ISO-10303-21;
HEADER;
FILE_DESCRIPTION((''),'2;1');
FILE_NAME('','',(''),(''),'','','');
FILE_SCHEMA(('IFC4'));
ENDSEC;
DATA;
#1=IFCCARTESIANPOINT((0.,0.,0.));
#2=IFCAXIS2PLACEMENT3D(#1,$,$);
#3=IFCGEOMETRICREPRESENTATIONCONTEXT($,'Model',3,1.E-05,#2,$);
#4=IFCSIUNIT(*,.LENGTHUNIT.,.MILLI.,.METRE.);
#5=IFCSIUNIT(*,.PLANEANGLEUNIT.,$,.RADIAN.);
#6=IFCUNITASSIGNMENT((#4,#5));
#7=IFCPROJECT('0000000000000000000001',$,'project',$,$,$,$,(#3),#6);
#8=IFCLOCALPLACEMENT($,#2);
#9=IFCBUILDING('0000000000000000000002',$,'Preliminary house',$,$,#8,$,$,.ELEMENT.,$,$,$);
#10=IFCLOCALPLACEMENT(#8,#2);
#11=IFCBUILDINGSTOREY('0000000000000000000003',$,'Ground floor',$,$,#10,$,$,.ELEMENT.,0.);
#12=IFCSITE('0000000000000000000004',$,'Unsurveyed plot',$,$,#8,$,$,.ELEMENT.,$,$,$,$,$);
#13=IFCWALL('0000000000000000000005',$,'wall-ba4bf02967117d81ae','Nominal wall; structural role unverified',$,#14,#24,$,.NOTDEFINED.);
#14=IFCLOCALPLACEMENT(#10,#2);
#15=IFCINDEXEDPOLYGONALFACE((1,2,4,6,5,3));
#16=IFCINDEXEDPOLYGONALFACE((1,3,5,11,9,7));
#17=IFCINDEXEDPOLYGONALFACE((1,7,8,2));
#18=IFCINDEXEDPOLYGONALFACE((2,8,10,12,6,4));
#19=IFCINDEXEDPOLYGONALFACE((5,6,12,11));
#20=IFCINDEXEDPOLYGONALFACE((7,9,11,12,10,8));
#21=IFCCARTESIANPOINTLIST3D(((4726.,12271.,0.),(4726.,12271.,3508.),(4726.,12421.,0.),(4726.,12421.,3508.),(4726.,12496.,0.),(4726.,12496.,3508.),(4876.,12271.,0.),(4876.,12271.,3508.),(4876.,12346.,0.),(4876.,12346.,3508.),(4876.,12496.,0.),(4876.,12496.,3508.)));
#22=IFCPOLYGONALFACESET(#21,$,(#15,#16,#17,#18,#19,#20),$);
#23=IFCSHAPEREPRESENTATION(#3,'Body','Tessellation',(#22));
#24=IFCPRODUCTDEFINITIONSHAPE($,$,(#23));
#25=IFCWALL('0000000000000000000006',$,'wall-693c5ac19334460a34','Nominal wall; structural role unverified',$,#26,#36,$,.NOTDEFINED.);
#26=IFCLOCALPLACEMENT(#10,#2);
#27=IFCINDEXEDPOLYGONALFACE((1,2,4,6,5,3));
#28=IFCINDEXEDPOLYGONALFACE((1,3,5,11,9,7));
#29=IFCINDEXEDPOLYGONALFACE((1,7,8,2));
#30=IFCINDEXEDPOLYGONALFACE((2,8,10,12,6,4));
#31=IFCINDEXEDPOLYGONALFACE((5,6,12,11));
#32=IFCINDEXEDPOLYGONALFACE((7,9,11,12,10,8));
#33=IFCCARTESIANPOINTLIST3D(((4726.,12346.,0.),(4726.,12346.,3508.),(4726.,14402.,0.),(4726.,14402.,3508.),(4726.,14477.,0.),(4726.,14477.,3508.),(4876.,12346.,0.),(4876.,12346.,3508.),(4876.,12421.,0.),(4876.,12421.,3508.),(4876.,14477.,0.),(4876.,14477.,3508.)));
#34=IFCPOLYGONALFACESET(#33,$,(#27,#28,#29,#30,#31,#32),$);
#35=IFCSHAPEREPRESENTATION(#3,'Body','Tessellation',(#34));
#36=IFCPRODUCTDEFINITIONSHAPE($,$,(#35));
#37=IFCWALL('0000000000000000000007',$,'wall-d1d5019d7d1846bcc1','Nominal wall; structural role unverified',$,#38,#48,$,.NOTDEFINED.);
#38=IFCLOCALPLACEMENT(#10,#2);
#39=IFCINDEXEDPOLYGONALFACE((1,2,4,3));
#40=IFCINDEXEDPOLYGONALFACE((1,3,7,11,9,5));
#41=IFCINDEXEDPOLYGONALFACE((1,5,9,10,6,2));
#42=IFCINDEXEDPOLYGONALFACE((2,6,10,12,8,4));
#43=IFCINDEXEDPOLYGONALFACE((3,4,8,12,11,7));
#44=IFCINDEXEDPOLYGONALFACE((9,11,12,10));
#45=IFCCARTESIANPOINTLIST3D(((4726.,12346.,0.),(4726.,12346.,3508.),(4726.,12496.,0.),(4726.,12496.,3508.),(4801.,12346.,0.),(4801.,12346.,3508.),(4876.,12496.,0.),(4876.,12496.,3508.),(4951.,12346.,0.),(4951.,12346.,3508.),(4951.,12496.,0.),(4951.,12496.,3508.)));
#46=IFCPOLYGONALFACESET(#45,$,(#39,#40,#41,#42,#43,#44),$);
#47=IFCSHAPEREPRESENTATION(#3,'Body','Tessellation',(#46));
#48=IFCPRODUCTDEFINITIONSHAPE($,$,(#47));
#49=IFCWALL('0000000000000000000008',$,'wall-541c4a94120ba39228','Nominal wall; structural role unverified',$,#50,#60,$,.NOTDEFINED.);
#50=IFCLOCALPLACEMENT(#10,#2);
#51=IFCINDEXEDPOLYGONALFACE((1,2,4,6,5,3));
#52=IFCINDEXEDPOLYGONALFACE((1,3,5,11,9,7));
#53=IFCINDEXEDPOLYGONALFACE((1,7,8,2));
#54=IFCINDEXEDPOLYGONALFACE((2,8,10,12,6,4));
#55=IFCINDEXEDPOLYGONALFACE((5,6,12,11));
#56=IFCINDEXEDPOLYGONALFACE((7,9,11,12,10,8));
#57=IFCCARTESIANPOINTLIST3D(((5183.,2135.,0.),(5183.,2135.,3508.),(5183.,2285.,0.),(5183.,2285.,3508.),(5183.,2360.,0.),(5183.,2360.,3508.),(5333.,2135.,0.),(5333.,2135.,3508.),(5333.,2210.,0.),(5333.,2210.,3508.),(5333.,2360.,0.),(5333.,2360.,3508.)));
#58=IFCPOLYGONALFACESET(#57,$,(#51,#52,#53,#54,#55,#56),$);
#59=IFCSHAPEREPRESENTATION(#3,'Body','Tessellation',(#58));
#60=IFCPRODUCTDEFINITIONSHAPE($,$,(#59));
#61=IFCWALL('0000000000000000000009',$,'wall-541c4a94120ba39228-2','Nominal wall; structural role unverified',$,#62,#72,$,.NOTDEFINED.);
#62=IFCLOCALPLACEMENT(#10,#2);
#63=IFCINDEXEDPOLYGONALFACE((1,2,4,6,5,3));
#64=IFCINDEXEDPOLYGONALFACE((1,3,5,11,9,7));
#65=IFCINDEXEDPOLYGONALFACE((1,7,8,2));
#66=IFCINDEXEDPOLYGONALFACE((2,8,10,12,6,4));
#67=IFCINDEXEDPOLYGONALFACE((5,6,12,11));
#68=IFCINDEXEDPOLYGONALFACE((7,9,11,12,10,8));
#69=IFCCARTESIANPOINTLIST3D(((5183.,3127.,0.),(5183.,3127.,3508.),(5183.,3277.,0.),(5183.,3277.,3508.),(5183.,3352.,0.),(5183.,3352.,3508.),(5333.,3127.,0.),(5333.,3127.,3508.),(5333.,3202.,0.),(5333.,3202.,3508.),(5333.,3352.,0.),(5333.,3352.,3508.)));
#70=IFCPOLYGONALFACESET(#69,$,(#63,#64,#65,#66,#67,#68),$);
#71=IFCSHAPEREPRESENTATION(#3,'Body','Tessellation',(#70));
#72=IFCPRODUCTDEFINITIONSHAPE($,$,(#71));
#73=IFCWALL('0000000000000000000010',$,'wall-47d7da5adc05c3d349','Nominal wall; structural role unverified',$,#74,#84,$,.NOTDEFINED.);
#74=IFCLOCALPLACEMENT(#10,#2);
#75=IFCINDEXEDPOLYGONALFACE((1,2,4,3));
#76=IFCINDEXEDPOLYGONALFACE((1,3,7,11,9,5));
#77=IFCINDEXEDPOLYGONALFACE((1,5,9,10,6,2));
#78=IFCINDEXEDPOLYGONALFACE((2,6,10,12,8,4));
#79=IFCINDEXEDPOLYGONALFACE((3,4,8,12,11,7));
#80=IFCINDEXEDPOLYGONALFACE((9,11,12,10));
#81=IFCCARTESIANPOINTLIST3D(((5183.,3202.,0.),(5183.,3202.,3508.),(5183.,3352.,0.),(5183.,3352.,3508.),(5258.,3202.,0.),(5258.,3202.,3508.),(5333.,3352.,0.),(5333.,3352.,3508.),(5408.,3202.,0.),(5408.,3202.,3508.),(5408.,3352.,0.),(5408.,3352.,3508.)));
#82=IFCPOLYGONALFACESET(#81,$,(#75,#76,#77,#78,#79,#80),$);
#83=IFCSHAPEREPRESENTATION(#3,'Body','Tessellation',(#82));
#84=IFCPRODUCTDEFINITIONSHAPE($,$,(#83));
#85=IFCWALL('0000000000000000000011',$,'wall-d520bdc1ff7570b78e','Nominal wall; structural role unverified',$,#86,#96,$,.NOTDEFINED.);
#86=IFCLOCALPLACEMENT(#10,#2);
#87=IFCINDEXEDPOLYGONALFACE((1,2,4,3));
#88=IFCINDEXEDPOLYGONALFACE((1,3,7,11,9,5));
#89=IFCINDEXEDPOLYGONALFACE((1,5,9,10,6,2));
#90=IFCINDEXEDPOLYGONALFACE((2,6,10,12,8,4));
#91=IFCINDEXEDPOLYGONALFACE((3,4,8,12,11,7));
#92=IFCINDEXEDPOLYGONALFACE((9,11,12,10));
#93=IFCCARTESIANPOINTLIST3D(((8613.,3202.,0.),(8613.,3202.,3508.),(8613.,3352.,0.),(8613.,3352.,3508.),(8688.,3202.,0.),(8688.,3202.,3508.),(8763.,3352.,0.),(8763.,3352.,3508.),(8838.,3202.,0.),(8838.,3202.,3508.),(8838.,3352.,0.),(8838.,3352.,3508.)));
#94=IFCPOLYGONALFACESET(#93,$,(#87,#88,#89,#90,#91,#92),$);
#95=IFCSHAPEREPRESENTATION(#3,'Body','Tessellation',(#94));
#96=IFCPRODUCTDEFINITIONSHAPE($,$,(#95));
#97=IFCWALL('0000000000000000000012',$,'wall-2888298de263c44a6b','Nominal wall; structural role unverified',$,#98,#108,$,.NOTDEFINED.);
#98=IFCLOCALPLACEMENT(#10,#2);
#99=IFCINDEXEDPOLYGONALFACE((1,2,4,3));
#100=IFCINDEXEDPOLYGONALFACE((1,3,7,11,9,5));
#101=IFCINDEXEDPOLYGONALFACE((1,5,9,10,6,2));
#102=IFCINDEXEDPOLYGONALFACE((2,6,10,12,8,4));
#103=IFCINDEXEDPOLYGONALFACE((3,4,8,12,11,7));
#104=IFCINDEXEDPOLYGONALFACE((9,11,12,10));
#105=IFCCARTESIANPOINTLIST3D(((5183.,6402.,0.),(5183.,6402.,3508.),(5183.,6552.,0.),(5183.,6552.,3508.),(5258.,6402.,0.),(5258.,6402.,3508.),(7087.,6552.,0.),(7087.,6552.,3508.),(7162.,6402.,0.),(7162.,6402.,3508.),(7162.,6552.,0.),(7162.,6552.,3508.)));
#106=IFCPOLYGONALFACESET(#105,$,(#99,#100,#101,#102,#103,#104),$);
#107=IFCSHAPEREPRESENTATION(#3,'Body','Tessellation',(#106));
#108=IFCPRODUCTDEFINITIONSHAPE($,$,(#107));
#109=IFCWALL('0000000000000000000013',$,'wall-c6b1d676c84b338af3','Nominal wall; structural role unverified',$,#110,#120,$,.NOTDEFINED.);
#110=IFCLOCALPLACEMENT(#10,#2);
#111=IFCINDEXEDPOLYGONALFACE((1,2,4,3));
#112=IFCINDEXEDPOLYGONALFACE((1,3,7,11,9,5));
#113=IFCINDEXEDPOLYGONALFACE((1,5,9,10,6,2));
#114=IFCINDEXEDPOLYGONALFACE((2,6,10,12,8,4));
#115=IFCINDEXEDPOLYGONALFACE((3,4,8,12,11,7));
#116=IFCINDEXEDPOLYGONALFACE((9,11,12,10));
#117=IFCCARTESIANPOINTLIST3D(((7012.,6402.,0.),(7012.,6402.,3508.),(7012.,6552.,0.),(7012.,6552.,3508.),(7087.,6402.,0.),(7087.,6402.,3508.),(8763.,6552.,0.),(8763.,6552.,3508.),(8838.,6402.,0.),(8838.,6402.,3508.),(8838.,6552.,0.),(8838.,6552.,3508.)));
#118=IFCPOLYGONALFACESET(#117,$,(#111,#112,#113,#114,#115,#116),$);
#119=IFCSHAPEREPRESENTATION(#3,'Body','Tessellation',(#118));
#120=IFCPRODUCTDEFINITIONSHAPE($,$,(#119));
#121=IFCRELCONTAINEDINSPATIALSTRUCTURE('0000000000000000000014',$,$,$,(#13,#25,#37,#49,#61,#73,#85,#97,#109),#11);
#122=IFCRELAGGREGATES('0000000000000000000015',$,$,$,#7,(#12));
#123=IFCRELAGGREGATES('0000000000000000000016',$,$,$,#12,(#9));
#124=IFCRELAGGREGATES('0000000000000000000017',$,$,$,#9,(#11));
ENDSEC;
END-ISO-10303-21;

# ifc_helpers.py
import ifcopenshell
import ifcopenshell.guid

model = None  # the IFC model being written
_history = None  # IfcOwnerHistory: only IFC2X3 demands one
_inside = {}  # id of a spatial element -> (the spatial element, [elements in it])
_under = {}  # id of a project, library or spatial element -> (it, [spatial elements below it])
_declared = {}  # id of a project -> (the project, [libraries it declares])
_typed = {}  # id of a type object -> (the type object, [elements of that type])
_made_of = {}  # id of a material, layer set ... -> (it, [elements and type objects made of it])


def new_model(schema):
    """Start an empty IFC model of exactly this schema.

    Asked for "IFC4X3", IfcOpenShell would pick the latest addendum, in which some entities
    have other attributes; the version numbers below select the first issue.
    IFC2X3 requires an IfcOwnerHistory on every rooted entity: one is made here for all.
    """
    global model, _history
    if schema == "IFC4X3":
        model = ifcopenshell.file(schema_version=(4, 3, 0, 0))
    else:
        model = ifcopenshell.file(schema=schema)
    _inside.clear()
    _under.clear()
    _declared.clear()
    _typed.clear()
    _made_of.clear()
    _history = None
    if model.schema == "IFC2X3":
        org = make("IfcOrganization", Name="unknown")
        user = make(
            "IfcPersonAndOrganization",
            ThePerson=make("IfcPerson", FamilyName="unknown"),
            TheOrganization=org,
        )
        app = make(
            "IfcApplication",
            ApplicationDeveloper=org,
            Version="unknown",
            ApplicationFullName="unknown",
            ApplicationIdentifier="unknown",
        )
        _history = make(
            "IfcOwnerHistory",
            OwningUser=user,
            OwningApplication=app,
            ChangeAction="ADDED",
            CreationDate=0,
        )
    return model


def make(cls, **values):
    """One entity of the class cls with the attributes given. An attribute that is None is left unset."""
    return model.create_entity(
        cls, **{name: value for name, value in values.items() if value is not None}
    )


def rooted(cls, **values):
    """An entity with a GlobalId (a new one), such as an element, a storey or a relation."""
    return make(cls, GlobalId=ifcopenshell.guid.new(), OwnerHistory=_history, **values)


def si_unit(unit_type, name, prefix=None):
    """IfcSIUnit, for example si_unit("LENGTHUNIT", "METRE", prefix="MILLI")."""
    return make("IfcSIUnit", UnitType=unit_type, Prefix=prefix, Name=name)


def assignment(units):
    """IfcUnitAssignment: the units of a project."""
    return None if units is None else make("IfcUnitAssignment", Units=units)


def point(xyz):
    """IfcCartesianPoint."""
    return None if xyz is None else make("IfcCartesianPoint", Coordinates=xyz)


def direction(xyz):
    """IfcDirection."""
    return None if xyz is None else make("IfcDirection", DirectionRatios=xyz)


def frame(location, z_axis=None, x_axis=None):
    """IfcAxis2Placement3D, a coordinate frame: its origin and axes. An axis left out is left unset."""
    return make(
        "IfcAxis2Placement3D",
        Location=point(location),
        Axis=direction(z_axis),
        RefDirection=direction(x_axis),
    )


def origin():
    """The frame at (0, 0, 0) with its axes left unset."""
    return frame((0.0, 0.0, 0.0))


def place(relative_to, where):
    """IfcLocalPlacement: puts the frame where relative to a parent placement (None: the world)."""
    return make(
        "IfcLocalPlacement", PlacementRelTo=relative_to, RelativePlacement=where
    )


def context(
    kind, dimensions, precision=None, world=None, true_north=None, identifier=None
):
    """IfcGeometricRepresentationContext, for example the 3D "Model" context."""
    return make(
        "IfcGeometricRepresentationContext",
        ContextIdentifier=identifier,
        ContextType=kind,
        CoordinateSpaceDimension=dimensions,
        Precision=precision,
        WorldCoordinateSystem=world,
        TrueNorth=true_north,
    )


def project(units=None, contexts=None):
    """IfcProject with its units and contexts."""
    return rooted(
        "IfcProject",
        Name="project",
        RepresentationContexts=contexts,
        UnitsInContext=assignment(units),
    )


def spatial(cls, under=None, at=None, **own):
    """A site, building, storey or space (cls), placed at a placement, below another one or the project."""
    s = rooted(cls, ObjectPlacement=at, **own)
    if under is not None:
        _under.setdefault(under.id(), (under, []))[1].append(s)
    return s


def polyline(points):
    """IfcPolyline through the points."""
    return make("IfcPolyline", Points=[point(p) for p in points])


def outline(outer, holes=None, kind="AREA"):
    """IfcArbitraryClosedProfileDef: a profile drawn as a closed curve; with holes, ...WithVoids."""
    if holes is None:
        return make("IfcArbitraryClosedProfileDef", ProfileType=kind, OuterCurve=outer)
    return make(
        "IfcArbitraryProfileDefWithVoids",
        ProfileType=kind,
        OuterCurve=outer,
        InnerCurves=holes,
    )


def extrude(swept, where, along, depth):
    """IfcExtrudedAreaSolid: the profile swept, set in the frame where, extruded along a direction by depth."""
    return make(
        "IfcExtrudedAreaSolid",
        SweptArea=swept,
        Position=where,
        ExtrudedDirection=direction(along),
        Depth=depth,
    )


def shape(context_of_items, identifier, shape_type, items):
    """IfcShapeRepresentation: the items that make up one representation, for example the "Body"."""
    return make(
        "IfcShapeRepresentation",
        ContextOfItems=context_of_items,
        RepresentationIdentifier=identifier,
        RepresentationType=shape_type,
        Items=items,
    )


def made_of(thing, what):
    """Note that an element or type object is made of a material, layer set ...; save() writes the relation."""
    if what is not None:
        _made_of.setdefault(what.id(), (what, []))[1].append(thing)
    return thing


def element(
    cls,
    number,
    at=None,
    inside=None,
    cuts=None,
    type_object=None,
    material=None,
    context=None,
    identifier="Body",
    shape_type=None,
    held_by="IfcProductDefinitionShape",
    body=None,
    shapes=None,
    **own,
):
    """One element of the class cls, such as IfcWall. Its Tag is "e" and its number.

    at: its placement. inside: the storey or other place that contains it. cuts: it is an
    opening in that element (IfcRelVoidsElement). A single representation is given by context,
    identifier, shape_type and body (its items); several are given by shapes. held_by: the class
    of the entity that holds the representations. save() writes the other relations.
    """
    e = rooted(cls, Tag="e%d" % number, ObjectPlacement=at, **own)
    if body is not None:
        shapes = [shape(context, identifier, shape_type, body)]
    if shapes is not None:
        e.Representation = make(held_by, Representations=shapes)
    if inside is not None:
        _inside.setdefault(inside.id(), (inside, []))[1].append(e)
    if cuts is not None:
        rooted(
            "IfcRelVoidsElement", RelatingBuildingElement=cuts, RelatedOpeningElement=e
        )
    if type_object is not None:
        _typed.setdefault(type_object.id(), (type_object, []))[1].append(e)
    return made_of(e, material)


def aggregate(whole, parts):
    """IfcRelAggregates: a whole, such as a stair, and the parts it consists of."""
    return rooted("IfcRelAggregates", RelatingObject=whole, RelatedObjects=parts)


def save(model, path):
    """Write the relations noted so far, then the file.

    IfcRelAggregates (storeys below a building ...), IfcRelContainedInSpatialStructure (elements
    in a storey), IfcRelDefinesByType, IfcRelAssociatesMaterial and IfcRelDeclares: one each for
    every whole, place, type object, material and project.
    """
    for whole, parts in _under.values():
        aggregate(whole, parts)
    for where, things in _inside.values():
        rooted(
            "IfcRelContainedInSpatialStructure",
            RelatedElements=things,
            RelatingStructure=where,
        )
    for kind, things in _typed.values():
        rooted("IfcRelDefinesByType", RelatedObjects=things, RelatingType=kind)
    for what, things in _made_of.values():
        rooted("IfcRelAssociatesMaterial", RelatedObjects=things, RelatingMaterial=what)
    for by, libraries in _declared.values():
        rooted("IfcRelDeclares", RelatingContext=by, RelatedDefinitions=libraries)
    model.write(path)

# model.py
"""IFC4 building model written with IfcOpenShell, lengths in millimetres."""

from ifc_helpers import new_model, si_unit, origin, place, context, project, spatial, polyline, outline, extrude, element, save


model = new_model("IFC4")

# Units and contexts
model_context = context("Model", 3, precision=1e-05, world=origin())
ifc_project = project(units=[si_unit("LENGTHUNIT", "METRE", prefix="MILLI"), si_unit("PLANEANGLEUNIT", "RADIAN")], contexts=[model_context])

# Site, building, storey
placement_1 = place(None, origin())
site = spatial("IfcSite", under=ifc_project, at=placement_1, Name="Unsurveyed plot", CompositionType="ELEMENT")
building = spatial("IfcBuilding", under=site, at=placement_1, Name="Preliminary house", CompositionType="ELEMENT")
placement_2 = place(placement_1, origin())
storey = spatial("IfcBuildingStorey", under=building, at=placement_2, Name="Ground floor", CompositionType="ELEMENT", Elevation=0.0)

# Walls
element("IfcWall", 1, at=placement_2, inside=storey, Name="wall-ba4bf02967117d81ae", Description="Nominal wall; structural role unverified", PredefinedType="NOTDEFINED", context=model_context, shape_type="SweptSolid", body=[
    extrude(outline(polyline([(4726.0, 12421.0), (4726.0, 12496.0), (4876.0, 12496.0), (4876.0, 12346.0), (4876.0, 12271.0), (4726.0, 12271.0), (4726.0, 12421.0)])), origin(), (0.0, 0.0, 1.0), 3508.0),
])
element("IfcWall", 2, at=placement_2, inside=storey, Name="wall-693c5ac19334460a34", Description="Nominal wall; structural role unverified", PredefinedType="NOTDEFINED", context=model_context, shape_type="SweptSolid", body=[
    extrude(outline(polyline([(4726.0, 14402.0), (4726.0, 14477.0), (4876.0, 14477.0), (4876.0, 12421.0), (4876.0, 12346.0), (4726.0, 12346.0), (4726.0, 14402.0)])), origin(), (0.0, 0.0, 1.0), 3508.0),
])
element("IfcWall", 3, at=placement_2, inside=storey, Name="wall-d1d5019d7d1846bcc1", Description="Nominal wall; structural role unverified", PredefinedType="NOTDEFINED", context=model_context, shape_type="SweptSolid", body=[
    extrude(outline(polyline([(4876.0, 12496.0), (4951.0, 12496.0), (4951.0, 12346.0), (4801.0, 12346.0), (4726.0, 12346.0), (4726.0, 12496.0), (4876.0, 12496.0)])), origin(), (0.0, 0.0, 1.0), 3508.0),
])

# Wall
element("IfcWall", 4, at=placement_2, inside=storey, Name="wall-541c4a94120ba39228", Description="Nominal wall; structural role unverified", PredefinedType="NOTDEFINED", context=model_context, shape_type="SweptSolid", body=[
    extrude(outline(polyline([(5183.0, 2285.0), (5183.0, 2360.0), (5333.0, 2360.0), (5333.0, 2210.0), (5333.0, 2135.0), (5183.0, 2135.0), (5183.0, 2285.0)])), origin(), (0.0, 0.0, 1.0), 3508.0),
])

# Wall
element("IfcWall", 5, at=placement_2, inside=storey, Name="wall-541c4a94120ba39228-2", Description="Nominal wall; structural role unverified", PredefinedType="NOTDEFINED", context=model_context, shape_type="SweptSolid", body=[
    extrude(outline(polyline([(5183.0, 3277.0), (5183.0, 3352.0), (5333.0, 3352.0), (5333.0, 3202.0), (5333.0, 3127.0), (5183.0, 3127.0), (5183.0, 3277.0)])), origin(), (0.0, 0.0, 1.0), 3508.0),
])

# Wall
element("IfcWall", 6, at=placement_2, inside=storey, Name="wall-47d7da5adc05c3d349", Description="Nominal wall; structural role unverified", PredefinedType="NOTDEFINED", context=model_context, shape_type="SweptSolid", body=[
    extrude(outline(polyline([(5333.0, 3352.0), (5408.0, 3352.0), (5408.0, 3202.0), (5258.0, 3202.0), (5183.0, 3202.0), (5183.0, 3352.0), (5333.0, 3352.0)])), origin(), (0.0, 0.0, 1.0), 3508.0),
])

# Walls
element("IfcWall", 7, at=placement_2, inside=storey, Name="wall-d520bdc1ff7570b78e", Description="Nominal wall; structural role unverified", PredefinedType="NOTDEFINED", context=model_context, shape_type="SweptSolid", body=[
    extrude(outline(polyline([(8763.0, 3352.0), (8838.0, 3352.0), (8838.0, 3202.0), (8688.0, 3202.0), (8613.0, 3202.0), (8613.0, 3352.0), (8763.0, 3352.0)])), origin(), (0.0, 0.0, 1.0), 3508.0),
])
element("IfcWall", 8, at=placement_2, inside=storey, Name="wall-2888298de263c44a6b", Description="Nominal wall; structural role unverified", PredefinedType="NOTDEFINED", context=model_context, shape_type="SweptSolid", body=[
    extrude(outline(polyline([(7087.0, 6552.0), (7162.0, 6552.0), (7162.0, 6402.0), (5258.0, 6402.0), (5183.0, 6402.0), (5183.0, 6552.0), (7087.0, 6552.0)])), origin(), (0.0, 0.0, 1.0), 3508.0),
])

# Wall
element("IfcWall", 9, at=placement_2, inside=storey, Name="wall-c6b1d676c84b338af3", Description="Nominal wall; structural role unverified", PredefinedType="NOTDEFINED", context=model_context, shape_type="SweptSolid", body=[
    extrude(outline(polyline([(8763.0, 6552.0), (8838.0, 6552.0), (8838.0, 6402.0), (7087.0, 6402.0), (7012.0, 6402.0), (7012.0, 6552.0), (8763.0, 6552.0)])), origin(), (0.0, 0.0, 1.0), 3508.0),
])

save(model, "model.ifc")
